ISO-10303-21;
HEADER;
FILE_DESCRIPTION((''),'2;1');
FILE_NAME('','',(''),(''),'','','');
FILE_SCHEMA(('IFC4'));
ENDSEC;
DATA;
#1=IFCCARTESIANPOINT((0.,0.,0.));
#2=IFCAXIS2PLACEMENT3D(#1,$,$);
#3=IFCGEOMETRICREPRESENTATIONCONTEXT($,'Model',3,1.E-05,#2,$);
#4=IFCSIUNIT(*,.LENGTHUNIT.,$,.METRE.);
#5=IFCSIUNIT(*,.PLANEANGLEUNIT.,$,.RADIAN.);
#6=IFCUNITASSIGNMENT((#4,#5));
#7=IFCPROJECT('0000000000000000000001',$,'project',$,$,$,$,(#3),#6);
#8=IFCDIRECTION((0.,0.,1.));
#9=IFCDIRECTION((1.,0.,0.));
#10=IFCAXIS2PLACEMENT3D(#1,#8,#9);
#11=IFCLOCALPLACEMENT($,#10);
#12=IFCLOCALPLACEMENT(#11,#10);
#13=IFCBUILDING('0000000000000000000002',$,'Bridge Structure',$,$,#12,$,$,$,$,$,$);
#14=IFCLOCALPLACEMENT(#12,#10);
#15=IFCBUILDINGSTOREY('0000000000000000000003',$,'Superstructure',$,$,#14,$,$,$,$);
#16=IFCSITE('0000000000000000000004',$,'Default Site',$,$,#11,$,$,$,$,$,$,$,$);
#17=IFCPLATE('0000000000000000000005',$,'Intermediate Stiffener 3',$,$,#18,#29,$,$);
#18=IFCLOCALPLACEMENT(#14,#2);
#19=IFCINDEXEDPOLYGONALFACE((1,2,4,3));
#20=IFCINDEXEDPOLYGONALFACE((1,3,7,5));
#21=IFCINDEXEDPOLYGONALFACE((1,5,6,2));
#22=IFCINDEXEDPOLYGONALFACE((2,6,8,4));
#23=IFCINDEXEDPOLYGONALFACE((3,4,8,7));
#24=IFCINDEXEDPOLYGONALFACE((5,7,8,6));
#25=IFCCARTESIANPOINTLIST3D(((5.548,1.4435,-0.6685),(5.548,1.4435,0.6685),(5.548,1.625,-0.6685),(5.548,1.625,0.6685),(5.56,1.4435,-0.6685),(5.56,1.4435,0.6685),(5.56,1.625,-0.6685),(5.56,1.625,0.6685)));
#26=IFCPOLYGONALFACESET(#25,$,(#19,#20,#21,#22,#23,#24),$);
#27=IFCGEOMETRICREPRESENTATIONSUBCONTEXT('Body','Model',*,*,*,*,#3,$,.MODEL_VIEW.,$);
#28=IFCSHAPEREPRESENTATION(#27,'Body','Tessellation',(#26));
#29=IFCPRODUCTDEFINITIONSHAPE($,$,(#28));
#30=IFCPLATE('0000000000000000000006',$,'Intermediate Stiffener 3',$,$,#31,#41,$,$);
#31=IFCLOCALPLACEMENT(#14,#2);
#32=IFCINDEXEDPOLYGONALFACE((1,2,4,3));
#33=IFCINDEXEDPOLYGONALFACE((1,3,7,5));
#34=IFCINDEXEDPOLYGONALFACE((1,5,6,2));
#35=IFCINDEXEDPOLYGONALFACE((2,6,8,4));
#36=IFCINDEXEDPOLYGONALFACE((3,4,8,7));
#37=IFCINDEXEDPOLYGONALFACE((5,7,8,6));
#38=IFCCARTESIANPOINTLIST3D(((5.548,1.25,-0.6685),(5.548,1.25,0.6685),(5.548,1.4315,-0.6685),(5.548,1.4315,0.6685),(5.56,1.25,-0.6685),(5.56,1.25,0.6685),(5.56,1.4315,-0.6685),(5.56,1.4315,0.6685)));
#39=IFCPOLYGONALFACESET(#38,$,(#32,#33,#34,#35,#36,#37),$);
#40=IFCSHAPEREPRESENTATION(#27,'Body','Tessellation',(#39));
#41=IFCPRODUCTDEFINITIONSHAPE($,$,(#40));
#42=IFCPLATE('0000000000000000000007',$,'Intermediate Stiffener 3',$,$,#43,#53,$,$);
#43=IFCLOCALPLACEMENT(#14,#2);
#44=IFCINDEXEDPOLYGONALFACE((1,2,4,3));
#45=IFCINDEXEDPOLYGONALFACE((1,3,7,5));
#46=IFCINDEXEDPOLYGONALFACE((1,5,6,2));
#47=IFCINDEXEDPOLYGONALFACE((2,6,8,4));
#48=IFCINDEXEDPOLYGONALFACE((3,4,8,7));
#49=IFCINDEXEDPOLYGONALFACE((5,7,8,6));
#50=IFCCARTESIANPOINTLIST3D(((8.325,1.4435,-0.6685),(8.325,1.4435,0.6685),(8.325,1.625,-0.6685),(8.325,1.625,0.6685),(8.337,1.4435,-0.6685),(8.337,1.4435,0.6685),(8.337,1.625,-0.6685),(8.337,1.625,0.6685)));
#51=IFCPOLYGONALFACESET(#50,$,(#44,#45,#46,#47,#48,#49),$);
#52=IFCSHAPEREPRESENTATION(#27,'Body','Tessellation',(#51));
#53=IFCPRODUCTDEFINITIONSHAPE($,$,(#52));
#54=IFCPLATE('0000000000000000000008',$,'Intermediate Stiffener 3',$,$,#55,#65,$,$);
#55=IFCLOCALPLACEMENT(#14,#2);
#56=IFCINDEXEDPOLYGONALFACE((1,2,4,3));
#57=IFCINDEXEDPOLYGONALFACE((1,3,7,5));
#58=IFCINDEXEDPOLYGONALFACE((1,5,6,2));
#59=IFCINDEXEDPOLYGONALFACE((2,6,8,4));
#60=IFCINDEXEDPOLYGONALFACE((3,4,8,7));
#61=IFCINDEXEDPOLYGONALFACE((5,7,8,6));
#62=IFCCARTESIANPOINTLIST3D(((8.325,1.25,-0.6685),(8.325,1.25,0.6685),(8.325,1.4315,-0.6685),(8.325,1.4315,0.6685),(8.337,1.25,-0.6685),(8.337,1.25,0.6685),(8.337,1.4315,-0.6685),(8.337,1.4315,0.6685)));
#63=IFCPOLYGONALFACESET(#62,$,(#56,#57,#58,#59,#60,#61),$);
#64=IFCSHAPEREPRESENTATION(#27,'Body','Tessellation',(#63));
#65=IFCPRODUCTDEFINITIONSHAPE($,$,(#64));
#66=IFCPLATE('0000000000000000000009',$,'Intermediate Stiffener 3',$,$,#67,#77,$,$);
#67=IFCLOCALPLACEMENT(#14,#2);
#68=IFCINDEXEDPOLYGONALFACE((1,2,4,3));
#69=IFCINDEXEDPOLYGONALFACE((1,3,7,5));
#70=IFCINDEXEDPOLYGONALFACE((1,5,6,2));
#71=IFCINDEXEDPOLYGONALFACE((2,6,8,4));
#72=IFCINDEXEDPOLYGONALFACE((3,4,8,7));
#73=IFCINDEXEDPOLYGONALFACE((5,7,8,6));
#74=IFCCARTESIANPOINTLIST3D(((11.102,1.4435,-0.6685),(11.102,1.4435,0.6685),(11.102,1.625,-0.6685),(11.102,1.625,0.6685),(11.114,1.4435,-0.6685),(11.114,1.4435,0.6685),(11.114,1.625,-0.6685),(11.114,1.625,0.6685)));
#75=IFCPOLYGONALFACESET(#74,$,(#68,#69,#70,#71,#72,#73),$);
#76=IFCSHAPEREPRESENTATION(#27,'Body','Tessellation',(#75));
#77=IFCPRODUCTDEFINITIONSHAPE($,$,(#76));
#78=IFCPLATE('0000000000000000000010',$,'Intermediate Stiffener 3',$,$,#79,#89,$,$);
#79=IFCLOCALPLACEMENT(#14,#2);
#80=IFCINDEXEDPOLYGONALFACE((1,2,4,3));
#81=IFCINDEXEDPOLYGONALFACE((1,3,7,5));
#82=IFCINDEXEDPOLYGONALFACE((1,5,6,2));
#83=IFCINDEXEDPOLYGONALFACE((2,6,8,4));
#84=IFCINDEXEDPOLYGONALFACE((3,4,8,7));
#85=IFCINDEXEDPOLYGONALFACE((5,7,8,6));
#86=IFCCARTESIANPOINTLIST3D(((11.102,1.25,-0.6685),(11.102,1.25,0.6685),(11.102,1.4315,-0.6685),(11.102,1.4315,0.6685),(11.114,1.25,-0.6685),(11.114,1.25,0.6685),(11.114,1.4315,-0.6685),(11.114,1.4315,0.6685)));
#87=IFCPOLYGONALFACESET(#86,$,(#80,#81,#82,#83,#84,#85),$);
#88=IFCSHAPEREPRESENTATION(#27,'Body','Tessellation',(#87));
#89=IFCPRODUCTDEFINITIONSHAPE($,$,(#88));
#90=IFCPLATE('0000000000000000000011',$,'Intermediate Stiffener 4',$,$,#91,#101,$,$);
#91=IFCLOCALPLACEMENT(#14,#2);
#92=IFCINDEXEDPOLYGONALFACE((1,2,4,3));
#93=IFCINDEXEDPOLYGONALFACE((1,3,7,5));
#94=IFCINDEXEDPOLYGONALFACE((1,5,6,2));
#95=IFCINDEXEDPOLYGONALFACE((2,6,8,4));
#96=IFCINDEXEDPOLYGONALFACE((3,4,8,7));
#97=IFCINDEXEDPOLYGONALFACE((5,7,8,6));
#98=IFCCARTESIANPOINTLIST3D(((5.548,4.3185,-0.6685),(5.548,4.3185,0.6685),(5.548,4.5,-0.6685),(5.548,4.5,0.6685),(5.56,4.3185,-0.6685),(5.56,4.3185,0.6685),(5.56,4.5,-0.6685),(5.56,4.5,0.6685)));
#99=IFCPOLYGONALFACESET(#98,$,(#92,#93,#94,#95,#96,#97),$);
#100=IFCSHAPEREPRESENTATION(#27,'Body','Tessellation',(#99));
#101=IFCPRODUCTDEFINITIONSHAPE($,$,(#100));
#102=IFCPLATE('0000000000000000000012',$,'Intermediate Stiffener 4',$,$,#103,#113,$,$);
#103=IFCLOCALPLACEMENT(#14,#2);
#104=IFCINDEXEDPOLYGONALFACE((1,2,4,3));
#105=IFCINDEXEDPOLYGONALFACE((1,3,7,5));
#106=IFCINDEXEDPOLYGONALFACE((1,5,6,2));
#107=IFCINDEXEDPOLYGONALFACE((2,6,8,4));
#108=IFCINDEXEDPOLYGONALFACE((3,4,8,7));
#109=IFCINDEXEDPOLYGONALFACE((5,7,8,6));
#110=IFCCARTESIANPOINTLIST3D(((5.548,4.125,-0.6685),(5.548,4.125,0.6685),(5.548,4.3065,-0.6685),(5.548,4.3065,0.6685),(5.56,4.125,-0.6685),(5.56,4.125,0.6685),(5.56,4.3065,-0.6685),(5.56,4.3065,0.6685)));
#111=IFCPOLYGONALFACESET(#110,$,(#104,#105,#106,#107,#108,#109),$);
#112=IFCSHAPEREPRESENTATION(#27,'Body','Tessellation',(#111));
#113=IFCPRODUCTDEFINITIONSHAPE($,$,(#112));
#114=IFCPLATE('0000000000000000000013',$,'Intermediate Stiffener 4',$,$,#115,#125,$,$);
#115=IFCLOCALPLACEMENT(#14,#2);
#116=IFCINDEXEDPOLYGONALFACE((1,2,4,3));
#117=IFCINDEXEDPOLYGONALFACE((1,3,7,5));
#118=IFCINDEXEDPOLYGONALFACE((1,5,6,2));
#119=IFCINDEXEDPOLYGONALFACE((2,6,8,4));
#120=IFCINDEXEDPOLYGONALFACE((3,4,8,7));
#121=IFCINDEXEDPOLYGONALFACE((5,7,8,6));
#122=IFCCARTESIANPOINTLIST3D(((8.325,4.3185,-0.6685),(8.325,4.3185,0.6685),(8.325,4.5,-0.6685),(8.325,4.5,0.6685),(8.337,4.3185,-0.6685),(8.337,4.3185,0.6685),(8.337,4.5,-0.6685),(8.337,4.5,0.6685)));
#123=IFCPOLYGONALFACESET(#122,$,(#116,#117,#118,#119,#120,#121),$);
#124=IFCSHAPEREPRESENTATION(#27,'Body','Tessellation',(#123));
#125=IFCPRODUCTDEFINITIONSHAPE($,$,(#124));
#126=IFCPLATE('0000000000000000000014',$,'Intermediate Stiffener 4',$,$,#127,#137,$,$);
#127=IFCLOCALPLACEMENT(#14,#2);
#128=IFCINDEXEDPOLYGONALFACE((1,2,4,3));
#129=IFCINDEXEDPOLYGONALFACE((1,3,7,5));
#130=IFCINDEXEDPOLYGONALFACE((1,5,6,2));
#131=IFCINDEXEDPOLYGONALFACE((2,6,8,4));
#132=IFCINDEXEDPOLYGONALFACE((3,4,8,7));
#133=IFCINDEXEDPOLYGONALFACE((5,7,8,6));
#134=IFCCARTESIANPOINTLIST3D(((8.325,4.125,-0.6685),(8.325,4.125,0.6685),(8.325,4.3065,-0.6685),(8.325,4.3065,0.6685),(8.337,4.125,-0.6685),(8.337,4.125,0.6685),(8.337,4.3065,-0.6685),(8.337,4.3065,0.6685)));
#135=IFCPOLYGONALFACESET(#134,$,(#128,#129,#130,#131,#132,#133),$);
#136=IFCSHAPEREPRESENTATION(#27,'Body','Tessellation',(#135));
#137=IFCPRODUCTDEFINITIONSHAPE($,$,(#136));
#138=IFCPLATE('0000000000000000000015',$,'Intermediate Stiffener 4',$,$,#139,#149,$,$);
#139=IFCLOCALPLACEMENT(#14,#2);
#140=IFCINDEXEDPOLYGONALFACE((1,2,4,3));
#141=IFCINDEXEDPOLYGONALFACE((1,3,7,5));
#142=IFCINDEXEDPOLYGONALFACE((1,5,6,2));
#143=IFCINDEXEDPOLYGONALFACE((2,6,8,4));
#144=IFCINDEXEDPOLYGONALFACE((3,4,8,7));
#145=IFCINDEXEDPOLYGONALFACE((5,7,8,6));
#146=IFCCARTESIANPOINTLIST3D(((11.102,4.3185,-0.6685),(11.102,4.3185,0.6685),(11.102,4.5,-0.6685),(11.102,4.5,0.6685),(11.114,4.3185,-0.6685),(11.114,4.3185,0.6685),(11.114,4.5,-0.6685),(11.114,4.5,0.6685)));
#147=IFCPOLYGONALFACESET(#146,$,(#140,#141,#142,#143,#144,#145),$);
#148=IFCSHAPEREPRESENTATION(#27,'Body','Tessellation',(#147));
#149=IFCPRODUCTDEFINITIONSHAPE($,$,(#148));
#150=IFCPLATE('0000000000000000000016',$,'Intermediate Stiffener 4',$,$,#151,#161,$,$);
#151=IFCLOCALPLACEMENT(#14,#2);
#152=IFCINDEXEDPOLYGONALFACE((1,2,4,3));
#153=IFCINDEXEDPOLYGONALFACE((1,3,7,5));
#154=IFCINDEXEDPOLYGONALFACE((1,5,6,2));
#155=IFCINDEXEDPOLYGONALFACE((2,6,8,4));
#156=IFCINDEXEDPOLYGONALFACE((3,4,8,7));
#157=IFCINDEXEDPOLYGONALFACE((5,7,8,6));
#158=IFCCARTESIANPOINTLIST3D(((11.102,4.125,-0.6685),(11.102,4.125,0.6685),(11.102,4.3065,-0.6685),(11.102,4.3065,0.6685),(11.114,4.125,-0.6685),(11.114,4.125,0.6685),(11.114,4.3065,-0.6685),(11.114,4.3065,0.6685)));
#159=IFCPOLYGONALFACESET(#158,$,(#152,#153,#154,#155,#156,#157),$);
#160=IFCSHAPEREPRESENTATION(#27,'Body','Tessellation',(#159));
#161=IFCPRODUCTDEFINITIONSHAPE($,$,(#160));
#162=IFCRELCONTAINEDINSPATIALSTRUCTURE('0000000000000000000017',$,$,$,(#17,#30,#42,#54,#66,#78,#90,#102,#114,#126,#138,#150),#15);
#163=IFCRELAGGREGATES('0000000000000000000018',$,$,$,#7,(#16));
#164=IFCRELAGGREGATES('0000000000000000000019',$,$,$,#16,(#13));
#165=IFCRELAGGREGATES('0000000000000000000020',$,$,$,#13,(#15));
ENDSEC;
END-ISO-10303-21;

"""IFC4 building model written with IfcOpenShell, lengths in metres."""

from ifc_helpers import new_model, si_unit, frame, origin, origin_with_axes, origin_2d_with_axis, place, context, subcontext, project, spatial, rectangle, extrude, element, save


model = new_model("IFC4")

# Units and contexts
model_context = context("Model", 3, precision=1e-05, world=origin())
body_context = subcontext(model_context, "Body", "Model", "MODEL_VIEW")
ifc_project = project(units=[si_unit("LENGTHUNIT", "METRE"), si_unit("PLANEANGLEUNIT", "RADIAN")], contexts=[model_context])

# Site, building, storey
site_placement = place(None, origin_with_axes())
site = spatial("IfcSite", under=ifc_project, at=site_placement, Name="Default Site")
building_placement = place(site_placement, origin_with_axes())
building = spatial("IfcBuilding", under=site, at=building_placement, Name="Bridge Structure")
storey_placement = place(building_placement, origin_with_axes())
storey = spatial("IfcBuildingStorey", under=building, at=storey_placement, Name="Superstructure")

# Plates
for number, where, z_axis, x_axis, name in (
    (1, (5.554, 1.5343, -0.6685), (0.0, 0.0, 1.0), (1.0, 0.0, 0.0), "Intermediate Stiffener 3"),
    (2, (5.554, 1.3408, -0.6685), (0.0, 0.0, 1.0), (1.0, 0.0, 0.0), "Intermediate Stiffener 3"),
    (3, (8.331, 1.5343, -0.6685), (0.0, 0.0, 1.0), (1.0, 0.0, 0.0), "Intermediate Stiffener 3"),
    (4, (8.331, 1.3408, -0.6685), (0.0, 0.0, 1.0), (1.0, 0.0, 0.0), "Intermediate Stiffener 3"),
    (5, (11.108, 1.5343, -0.6685), (0.0, 0.0, 1.0), (1.0, 0.0, 0.0), "Intermediate Stiffener 3"),
    (6, (11.108, 1.3408, -0.6685), (0.0, 0.0, 1.0), (1.0, 0.0, 0.0), "Intermediate Stiffener 3"),
    (7, (5.554, 4.4093, -0.6685), (0.0, 0.0, 1.0), (1.0, 0.0, 0.0), "Intermediate Stiffener 4"),
    (8, (5.554, 4.2157, -0.6685), (0.0, 0.0, 1.0), (1.0, 0.0, 0.0), "Intermediate Stiffener 4"),
    (9, (8.331, 4.4093, -0.6685), (0.0, 0.0, 1.0), (1.0, 0.0, 0.0), "Intermediate Stiffener 4"),
    (10, (8.331, 4.2157, -0.6685), (0.0, 0.0, 1.0), (1.0, 0.0, 0.0), "Intermediate Stiffener 4"),
    (11, (11.108, 4.4093, -0.6685), (0.0, 0.0, 1.0), (1.0, 0.0, 0.0), "Intermediate Stiffener 4"),
    (12, (11.108, 4.2157, -0.6685), (0.0, 0.0, 1.0), (1.0, 0.0, 0.0), "Intermediate Stiffener 4"),
):
    element("IfcPlate", number, at=place(storey_placement, frame(where, z_axis=z_axis, x_axis=x_axis)), inside=storey, Name=name, context=body_context, shape_type="SweptSolid", body=[
        extrude(rectangle(XDim=0.012, YDim=0.1815, at=origin_2d_with_axis()), origin_with_axes(), (0.0, 0.0, 1.0), 1.337),
    ])

save(model, "model.ifc")
